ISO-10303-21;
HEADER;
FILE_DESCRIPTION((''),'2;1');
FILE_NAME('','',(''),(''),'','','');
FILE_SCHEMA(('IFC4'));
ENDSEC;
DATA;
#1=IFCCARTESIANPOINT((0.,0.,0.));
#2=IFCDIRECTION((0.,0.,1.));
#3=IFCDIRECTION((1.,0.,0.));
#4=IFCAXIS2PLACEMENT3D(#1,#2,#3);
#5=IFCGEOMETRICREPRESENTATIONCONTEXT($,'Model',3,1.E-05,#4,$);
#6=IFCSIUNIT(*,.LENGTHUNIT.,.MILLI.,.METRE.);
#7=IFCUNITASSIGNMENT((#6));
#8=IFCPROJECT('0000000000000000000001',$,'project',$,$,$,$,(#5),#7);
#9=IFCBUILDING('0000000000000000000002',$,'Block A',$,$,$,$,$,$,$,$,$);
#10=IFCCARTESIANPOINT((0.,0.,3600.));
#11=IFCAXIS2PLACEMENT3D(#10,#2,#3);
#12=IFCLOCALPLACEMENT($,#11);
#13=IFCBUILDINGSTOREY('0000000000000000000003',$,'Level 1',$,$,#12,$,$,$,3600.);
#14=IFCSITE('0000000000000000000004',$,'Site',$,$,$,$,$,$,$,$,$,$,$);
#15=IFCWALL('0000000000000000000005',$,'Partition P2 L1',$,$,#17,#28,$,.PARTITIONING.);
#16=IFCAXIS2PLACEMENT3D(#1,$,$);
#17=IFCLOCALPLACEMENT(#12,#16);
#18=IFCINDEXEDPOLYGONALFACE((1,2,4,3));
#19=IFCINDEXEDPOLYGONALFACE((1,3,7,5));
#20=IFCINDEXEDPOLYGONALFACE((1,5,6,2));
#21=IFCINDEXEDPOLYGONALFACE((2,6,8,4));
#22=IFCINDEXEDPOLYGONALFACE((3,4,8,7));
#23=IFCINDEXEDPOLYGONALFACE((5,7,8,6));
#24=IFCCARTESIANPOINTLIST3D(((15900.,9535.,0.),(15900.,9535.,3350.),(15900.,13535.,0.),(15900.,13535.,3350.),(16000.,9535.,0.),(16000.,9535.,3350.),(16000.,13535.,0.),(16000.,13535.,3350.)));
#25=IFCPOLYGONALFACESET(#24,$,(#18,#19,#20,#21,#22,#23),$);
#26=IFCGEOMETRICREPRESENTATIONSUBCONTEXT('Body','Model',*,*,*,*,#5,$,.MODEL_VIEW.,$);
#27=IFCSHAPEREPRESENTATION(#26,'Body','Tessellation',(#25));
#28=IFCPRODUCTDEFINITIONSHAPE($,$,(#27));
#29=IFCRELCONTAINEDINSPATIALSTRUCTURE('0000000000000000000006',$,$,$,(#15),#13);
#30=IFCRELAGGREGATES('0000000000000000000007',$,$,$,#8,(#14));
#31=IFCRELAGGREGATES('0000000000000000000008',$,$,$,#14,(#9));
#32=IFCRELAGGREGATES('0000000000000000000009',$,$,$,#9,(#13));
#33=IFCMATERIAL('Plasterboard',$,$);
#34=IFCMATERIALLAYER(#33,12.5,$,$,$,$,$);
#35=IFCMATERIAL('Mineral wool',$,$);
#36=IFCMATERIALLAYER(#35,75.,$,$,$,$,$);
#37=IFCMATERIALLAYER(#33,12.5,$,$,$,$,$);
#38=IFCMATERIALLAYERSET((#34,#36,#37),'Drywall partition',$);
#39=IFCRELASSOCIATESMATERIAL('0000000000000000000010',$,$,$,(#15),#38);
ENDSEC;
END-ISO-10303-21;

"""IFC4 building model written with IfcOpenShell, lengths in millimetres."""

from ifc_helpers import new_model, si_unit, frame, origin_with_axes, place, context, subcontext, project, spatial, indexed_curve, outline, extrude, material, layer, layer_set, layer_usage, element, save


model = new_model("IFC4")

# Units and contexts
model_context = context("Model", 3, precision=1e-05, world=origin_with_axes())
body_context = subcontext(model_context, "Body", "Model", "MODEL_VIEW")
ifc_project = project(units=[si_unit("LENGTHUNIT", "METRE", prefix="MILLI")], contexts=[model_context])

# Site, building, storey
site = spatial("IfcSite", under=ifc_project, Name="Site")
building = spatial("IfcBuilding", under=site, Name="Block A")
storey_placement = place(None, frame((0.0, 0.0, 3600.0), z_axis=(0.0, 0.0, 1.0), x_axis=(1.0, 0.0, 0.0)))
storey = spatial("IfcBuildingStorey", under=building, at=storey_placement, Name="Level 1", Elevation=3600.0)

# Shared definitions
ifc_material_1 = material(Name="Mineral wool")

# Wall
ifc_material_2 = material(Name="Plasterboard")
ifc_layer_1 = layer(ifc_material_2, 12.5)
ifc_layer_2 = layer(ifc_material_1, 75.0)
ifc_layer_3 = layer(ifc_material_2, 12.5)
ifc_layer_set_1 = layer_set([ifc_layer_1, ifc_layer_2, ifc_layer_3], Name="Drywall partition")
ifc_layer_usage_1 = layer_usage(ifc_layer_set_1, "AXIS2", "POSITIVE", 0.0)
wall_1_placement = place(storey_placement, frame((16000.0, 9535.0, 0.0), z_axis=(0.0, 0.0, 1.0), x_axis=(0.0, 1.0, 0.0)))
element("IfcWall", 1, at=wall_1_placement, inside=storey, material=ifc_layer_usage_1, Name="Partition P2 L1", PredefinedType="PARTITIONING", context=body_context, shape_type="SweptSolid", body=[
    extrude(outline(indexed_curve([(0.0, 0.0), (0.0, 100.0), (4000.0, 100.0), (4000.0, 0.0), (0.0, 0.0)], self_intersect=False)), origin_with_axes(), (0.0, 0.0, 1.0), 3350.0),
])

save(model, "model.ifc")
